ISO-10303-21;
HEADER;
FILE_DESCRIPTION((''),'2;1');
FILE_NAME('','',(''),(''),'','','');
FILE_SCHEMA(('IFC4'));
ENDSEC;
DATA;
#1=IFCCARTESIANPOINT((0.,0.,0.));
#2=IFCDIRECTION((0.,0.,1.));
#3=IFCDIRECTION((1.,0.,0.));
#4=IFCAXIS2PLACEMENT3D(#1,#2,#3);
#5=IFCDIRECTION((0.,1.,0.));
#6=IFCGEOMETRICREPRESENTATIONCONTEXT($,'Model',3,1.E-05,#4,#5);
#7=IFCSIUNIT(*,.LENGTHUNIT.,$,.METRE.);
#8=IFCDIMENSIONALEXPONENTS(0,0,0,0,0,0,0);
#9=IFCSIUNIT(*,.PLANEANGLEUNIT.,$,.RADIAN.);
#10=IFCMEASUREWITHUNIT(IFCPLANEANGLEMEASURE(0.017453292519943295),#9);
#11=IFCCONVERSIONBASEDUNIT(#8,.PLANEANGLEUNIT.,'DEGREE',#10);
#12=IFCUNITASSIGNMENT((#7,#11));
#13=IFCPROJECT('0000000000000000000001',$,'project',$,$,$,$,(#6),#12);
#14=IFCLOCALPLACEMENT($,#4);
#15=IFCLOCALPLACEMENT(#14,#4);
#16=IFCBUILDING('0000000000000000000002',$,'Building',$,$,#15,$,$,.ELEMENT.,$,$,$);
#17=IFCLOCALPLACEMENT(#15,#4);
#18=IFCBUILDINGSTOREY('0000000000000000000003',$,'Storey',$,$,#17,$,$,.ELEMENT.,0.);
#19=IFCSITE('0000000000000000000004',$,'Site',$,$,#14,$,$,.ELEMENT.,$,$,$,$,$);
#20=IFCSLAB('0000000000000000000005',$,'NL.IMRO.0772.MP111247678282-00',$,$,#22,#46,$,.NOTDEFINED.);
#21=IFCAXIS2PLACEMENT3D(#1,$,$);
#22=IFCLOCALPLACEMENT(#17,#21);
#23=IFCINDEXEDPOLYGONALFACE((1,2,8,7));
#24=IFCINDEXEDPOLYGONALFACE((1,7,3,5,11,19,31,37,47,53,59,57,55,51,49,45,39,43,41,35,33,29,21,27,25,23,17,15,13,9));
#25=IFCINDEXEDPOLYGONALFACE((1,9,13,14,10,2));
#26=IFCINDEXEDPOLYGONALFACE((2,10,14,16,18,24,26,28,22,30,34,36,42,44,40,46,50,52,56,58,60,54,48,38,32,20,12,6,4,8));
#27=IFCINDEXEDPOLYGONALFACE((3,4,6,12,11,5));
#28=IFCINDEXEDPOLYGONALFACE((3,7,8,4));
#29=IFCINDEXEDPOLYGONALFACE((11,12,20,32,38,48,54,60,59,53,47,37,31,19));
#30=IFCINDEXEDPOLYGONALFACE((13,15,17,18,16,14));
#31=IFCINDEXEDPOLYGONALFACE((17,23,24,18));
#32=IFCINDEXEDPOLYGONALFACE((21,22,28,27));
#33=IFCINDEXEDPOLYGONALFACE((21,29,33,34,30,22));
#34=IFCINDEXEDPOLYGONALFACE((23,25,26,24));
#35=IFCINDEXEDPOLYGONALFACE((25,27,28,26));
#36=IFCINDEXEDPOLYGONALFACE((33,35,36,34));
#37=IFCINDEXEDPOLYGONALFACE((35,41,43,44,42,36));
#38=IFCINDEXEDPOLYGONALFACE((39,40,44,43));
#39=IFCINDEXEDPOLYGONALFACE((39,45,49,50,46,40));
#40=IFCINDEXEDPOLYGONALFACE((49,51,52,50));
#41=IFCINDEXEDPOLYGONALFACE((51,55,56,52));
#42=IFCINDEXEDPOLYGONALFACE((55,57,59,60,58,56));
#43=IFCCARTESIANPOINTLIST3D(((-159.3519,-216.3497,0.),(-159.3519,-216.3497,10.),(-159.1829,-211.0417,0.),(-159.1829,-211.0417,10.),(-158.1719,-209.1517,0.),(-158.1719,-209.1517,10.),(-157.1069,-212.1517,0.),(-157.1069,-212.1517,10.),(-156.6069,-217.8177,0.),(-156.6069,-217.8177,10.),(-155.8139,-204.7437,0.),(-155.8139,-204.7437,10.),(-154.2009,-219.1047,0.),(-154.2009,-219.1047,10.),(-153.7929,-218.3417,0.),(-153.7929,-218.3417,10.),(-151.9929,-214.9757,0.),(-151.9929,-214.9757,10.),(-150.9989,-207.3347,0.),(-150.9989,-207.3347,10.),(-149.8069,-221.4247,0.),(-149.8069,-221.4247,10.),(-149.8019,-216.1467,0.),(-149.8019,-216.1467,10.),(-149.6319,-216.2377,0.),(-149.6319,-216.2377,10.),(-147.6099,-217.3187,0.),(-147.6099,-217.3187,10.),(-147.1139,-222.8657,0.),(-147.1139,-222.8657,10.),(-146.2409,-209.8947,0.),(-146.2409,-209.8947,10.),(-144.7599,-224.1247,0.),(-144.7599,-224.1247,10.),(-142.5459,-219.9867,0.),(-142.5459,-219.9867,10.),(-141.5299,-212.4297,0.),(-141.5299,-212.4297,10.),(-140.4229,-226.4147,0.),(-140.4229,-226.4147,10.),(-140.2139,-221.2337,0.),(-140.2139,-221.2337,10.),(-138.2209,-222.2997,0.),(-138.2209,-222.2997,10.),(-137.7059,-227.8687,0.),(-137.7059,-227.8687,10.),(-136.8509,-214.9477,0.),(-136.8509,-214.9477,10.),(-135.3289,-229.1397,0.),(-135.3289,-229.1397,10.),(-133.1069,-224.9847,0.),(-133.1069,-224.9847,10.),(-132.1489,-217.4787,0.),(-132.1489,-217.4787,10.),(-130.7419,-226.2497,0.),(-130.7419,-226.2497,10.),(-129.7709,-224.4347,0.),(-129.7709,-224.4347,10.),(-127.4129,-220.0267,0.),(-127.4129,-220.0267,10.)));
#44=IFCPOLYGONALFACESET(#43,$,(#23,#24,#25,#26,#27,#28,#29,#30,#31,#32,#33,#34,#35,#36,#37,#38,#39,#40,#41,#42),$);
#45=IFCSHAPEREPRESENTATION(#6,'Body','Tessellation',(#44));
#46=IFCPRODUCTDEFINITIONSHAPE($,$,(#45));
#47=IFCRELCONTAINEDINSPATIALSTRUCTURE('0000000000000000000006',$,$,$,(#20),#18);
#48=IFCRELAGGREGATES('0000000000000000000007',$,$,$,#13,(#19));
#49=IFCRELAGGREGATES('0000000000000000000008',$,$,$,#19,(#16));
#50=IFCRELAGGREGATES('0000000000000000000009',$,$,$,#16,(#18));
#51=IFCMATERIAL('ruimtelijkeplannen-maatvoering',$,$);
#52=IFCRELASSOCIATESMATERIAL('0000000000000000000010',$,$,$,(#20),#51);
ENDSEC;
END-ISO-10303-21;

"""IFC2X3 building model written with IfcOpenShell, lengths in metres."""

from ifc_helpers import new_model, entity, si_unit, converted_unit, direction, origin_with_axes, place, context, project, spatial, polyline, outline, extrude, material, element, save


model = new_model("IFC2X3")

# Units and contexts
model_context = context("Model", 3, precision=1e-05, world=origin_with_axes(), true_north=direction((0.0, 1.0, 0.0)))
ifc_project = project(units=[si_unit("LENGTHUNIT", "METRE"), converted_unit("PLANEANGLEUNIT", "DEGREE", entity("IfcPlaneAngleMeasure", 0.017453292519943295), si_unit("PLANEANGLEUNIT", "RADIAN"), dimensions=[0, 0, 0, 0, 0, 0, 0])], contexts=[model_context])

# Site, building, storey
site_placement = place(None, origin_with_axes())
site = spatial("IfcSite", under=ifc_project, at=site_placement, Name="Site", CompositionType="ELEMENT")
building_placement = place(site_placement, origin_with_axes())
building = spatial("IfcBuilding", under=site, at=building_placement, Name="Building", CompositionType="ELEMENT")
storey_placement = place(building_placement, origin_with_axes())
storey = spatial("IfcBuildingStorey", under=building, at=storey_placement, Name="Storey", CompositionType="ELEMENT", Elevation=0.0)

# Slab
ifc_material = material(Name="ruimtelijkeplannen-maatvoering")
slab_1_placement = place(storey_placement, origin_with_axes())
element("IfcSlab", 1, at=slab_1_placement, inside=storey, material=ifc_material, Name="NL.IMRO.0772.MP111247678282-00", PredefinedType="NOTDEFINED", context=model_context, shape_type="SweptSolid", body=[
    extrude(outline(polyline([(-127.4129, -220.0267), (-129.7709, -224.4347), (-130.7419, -226.2497), (-133.1069, -224.9847), (-135.3289, -229.1397), (-137.7059, -227.8687), (-140.4229, -226.4147), (-138.2209, -222.2997), (-140.2139, -221.2337), (-142.5459, -219.9867), (-144.7599, -224.1247), (-147.1139, -222.8657), (-149.8069, -221.4247), (-147.6099, -217.3187), (-149.6319, -216.2377), (-149.8019, -216.1467), (-151.9929, -214.9757), (-153.7929, -218.3417), (-154.2009, -219.1047), (-156.6069, -217.8177), (-159.3519, -216.3497), (-157.1069, -212.1517), (-159.1829, -211.0417), (-158.1719, -209.1517), (-155.8139, -204.7437), (-150.9989, -207.3347), (-146.2409, -209.8947), (-141.5299, -212.4297), (-136.8509, -214.9477), (-132.1489, -217.4787), (-127.4129, -220.0267)])), origin_with_axes(), (0.0, 0.0, 1.0), 10.0),
])

save(model, "model.ifc")
